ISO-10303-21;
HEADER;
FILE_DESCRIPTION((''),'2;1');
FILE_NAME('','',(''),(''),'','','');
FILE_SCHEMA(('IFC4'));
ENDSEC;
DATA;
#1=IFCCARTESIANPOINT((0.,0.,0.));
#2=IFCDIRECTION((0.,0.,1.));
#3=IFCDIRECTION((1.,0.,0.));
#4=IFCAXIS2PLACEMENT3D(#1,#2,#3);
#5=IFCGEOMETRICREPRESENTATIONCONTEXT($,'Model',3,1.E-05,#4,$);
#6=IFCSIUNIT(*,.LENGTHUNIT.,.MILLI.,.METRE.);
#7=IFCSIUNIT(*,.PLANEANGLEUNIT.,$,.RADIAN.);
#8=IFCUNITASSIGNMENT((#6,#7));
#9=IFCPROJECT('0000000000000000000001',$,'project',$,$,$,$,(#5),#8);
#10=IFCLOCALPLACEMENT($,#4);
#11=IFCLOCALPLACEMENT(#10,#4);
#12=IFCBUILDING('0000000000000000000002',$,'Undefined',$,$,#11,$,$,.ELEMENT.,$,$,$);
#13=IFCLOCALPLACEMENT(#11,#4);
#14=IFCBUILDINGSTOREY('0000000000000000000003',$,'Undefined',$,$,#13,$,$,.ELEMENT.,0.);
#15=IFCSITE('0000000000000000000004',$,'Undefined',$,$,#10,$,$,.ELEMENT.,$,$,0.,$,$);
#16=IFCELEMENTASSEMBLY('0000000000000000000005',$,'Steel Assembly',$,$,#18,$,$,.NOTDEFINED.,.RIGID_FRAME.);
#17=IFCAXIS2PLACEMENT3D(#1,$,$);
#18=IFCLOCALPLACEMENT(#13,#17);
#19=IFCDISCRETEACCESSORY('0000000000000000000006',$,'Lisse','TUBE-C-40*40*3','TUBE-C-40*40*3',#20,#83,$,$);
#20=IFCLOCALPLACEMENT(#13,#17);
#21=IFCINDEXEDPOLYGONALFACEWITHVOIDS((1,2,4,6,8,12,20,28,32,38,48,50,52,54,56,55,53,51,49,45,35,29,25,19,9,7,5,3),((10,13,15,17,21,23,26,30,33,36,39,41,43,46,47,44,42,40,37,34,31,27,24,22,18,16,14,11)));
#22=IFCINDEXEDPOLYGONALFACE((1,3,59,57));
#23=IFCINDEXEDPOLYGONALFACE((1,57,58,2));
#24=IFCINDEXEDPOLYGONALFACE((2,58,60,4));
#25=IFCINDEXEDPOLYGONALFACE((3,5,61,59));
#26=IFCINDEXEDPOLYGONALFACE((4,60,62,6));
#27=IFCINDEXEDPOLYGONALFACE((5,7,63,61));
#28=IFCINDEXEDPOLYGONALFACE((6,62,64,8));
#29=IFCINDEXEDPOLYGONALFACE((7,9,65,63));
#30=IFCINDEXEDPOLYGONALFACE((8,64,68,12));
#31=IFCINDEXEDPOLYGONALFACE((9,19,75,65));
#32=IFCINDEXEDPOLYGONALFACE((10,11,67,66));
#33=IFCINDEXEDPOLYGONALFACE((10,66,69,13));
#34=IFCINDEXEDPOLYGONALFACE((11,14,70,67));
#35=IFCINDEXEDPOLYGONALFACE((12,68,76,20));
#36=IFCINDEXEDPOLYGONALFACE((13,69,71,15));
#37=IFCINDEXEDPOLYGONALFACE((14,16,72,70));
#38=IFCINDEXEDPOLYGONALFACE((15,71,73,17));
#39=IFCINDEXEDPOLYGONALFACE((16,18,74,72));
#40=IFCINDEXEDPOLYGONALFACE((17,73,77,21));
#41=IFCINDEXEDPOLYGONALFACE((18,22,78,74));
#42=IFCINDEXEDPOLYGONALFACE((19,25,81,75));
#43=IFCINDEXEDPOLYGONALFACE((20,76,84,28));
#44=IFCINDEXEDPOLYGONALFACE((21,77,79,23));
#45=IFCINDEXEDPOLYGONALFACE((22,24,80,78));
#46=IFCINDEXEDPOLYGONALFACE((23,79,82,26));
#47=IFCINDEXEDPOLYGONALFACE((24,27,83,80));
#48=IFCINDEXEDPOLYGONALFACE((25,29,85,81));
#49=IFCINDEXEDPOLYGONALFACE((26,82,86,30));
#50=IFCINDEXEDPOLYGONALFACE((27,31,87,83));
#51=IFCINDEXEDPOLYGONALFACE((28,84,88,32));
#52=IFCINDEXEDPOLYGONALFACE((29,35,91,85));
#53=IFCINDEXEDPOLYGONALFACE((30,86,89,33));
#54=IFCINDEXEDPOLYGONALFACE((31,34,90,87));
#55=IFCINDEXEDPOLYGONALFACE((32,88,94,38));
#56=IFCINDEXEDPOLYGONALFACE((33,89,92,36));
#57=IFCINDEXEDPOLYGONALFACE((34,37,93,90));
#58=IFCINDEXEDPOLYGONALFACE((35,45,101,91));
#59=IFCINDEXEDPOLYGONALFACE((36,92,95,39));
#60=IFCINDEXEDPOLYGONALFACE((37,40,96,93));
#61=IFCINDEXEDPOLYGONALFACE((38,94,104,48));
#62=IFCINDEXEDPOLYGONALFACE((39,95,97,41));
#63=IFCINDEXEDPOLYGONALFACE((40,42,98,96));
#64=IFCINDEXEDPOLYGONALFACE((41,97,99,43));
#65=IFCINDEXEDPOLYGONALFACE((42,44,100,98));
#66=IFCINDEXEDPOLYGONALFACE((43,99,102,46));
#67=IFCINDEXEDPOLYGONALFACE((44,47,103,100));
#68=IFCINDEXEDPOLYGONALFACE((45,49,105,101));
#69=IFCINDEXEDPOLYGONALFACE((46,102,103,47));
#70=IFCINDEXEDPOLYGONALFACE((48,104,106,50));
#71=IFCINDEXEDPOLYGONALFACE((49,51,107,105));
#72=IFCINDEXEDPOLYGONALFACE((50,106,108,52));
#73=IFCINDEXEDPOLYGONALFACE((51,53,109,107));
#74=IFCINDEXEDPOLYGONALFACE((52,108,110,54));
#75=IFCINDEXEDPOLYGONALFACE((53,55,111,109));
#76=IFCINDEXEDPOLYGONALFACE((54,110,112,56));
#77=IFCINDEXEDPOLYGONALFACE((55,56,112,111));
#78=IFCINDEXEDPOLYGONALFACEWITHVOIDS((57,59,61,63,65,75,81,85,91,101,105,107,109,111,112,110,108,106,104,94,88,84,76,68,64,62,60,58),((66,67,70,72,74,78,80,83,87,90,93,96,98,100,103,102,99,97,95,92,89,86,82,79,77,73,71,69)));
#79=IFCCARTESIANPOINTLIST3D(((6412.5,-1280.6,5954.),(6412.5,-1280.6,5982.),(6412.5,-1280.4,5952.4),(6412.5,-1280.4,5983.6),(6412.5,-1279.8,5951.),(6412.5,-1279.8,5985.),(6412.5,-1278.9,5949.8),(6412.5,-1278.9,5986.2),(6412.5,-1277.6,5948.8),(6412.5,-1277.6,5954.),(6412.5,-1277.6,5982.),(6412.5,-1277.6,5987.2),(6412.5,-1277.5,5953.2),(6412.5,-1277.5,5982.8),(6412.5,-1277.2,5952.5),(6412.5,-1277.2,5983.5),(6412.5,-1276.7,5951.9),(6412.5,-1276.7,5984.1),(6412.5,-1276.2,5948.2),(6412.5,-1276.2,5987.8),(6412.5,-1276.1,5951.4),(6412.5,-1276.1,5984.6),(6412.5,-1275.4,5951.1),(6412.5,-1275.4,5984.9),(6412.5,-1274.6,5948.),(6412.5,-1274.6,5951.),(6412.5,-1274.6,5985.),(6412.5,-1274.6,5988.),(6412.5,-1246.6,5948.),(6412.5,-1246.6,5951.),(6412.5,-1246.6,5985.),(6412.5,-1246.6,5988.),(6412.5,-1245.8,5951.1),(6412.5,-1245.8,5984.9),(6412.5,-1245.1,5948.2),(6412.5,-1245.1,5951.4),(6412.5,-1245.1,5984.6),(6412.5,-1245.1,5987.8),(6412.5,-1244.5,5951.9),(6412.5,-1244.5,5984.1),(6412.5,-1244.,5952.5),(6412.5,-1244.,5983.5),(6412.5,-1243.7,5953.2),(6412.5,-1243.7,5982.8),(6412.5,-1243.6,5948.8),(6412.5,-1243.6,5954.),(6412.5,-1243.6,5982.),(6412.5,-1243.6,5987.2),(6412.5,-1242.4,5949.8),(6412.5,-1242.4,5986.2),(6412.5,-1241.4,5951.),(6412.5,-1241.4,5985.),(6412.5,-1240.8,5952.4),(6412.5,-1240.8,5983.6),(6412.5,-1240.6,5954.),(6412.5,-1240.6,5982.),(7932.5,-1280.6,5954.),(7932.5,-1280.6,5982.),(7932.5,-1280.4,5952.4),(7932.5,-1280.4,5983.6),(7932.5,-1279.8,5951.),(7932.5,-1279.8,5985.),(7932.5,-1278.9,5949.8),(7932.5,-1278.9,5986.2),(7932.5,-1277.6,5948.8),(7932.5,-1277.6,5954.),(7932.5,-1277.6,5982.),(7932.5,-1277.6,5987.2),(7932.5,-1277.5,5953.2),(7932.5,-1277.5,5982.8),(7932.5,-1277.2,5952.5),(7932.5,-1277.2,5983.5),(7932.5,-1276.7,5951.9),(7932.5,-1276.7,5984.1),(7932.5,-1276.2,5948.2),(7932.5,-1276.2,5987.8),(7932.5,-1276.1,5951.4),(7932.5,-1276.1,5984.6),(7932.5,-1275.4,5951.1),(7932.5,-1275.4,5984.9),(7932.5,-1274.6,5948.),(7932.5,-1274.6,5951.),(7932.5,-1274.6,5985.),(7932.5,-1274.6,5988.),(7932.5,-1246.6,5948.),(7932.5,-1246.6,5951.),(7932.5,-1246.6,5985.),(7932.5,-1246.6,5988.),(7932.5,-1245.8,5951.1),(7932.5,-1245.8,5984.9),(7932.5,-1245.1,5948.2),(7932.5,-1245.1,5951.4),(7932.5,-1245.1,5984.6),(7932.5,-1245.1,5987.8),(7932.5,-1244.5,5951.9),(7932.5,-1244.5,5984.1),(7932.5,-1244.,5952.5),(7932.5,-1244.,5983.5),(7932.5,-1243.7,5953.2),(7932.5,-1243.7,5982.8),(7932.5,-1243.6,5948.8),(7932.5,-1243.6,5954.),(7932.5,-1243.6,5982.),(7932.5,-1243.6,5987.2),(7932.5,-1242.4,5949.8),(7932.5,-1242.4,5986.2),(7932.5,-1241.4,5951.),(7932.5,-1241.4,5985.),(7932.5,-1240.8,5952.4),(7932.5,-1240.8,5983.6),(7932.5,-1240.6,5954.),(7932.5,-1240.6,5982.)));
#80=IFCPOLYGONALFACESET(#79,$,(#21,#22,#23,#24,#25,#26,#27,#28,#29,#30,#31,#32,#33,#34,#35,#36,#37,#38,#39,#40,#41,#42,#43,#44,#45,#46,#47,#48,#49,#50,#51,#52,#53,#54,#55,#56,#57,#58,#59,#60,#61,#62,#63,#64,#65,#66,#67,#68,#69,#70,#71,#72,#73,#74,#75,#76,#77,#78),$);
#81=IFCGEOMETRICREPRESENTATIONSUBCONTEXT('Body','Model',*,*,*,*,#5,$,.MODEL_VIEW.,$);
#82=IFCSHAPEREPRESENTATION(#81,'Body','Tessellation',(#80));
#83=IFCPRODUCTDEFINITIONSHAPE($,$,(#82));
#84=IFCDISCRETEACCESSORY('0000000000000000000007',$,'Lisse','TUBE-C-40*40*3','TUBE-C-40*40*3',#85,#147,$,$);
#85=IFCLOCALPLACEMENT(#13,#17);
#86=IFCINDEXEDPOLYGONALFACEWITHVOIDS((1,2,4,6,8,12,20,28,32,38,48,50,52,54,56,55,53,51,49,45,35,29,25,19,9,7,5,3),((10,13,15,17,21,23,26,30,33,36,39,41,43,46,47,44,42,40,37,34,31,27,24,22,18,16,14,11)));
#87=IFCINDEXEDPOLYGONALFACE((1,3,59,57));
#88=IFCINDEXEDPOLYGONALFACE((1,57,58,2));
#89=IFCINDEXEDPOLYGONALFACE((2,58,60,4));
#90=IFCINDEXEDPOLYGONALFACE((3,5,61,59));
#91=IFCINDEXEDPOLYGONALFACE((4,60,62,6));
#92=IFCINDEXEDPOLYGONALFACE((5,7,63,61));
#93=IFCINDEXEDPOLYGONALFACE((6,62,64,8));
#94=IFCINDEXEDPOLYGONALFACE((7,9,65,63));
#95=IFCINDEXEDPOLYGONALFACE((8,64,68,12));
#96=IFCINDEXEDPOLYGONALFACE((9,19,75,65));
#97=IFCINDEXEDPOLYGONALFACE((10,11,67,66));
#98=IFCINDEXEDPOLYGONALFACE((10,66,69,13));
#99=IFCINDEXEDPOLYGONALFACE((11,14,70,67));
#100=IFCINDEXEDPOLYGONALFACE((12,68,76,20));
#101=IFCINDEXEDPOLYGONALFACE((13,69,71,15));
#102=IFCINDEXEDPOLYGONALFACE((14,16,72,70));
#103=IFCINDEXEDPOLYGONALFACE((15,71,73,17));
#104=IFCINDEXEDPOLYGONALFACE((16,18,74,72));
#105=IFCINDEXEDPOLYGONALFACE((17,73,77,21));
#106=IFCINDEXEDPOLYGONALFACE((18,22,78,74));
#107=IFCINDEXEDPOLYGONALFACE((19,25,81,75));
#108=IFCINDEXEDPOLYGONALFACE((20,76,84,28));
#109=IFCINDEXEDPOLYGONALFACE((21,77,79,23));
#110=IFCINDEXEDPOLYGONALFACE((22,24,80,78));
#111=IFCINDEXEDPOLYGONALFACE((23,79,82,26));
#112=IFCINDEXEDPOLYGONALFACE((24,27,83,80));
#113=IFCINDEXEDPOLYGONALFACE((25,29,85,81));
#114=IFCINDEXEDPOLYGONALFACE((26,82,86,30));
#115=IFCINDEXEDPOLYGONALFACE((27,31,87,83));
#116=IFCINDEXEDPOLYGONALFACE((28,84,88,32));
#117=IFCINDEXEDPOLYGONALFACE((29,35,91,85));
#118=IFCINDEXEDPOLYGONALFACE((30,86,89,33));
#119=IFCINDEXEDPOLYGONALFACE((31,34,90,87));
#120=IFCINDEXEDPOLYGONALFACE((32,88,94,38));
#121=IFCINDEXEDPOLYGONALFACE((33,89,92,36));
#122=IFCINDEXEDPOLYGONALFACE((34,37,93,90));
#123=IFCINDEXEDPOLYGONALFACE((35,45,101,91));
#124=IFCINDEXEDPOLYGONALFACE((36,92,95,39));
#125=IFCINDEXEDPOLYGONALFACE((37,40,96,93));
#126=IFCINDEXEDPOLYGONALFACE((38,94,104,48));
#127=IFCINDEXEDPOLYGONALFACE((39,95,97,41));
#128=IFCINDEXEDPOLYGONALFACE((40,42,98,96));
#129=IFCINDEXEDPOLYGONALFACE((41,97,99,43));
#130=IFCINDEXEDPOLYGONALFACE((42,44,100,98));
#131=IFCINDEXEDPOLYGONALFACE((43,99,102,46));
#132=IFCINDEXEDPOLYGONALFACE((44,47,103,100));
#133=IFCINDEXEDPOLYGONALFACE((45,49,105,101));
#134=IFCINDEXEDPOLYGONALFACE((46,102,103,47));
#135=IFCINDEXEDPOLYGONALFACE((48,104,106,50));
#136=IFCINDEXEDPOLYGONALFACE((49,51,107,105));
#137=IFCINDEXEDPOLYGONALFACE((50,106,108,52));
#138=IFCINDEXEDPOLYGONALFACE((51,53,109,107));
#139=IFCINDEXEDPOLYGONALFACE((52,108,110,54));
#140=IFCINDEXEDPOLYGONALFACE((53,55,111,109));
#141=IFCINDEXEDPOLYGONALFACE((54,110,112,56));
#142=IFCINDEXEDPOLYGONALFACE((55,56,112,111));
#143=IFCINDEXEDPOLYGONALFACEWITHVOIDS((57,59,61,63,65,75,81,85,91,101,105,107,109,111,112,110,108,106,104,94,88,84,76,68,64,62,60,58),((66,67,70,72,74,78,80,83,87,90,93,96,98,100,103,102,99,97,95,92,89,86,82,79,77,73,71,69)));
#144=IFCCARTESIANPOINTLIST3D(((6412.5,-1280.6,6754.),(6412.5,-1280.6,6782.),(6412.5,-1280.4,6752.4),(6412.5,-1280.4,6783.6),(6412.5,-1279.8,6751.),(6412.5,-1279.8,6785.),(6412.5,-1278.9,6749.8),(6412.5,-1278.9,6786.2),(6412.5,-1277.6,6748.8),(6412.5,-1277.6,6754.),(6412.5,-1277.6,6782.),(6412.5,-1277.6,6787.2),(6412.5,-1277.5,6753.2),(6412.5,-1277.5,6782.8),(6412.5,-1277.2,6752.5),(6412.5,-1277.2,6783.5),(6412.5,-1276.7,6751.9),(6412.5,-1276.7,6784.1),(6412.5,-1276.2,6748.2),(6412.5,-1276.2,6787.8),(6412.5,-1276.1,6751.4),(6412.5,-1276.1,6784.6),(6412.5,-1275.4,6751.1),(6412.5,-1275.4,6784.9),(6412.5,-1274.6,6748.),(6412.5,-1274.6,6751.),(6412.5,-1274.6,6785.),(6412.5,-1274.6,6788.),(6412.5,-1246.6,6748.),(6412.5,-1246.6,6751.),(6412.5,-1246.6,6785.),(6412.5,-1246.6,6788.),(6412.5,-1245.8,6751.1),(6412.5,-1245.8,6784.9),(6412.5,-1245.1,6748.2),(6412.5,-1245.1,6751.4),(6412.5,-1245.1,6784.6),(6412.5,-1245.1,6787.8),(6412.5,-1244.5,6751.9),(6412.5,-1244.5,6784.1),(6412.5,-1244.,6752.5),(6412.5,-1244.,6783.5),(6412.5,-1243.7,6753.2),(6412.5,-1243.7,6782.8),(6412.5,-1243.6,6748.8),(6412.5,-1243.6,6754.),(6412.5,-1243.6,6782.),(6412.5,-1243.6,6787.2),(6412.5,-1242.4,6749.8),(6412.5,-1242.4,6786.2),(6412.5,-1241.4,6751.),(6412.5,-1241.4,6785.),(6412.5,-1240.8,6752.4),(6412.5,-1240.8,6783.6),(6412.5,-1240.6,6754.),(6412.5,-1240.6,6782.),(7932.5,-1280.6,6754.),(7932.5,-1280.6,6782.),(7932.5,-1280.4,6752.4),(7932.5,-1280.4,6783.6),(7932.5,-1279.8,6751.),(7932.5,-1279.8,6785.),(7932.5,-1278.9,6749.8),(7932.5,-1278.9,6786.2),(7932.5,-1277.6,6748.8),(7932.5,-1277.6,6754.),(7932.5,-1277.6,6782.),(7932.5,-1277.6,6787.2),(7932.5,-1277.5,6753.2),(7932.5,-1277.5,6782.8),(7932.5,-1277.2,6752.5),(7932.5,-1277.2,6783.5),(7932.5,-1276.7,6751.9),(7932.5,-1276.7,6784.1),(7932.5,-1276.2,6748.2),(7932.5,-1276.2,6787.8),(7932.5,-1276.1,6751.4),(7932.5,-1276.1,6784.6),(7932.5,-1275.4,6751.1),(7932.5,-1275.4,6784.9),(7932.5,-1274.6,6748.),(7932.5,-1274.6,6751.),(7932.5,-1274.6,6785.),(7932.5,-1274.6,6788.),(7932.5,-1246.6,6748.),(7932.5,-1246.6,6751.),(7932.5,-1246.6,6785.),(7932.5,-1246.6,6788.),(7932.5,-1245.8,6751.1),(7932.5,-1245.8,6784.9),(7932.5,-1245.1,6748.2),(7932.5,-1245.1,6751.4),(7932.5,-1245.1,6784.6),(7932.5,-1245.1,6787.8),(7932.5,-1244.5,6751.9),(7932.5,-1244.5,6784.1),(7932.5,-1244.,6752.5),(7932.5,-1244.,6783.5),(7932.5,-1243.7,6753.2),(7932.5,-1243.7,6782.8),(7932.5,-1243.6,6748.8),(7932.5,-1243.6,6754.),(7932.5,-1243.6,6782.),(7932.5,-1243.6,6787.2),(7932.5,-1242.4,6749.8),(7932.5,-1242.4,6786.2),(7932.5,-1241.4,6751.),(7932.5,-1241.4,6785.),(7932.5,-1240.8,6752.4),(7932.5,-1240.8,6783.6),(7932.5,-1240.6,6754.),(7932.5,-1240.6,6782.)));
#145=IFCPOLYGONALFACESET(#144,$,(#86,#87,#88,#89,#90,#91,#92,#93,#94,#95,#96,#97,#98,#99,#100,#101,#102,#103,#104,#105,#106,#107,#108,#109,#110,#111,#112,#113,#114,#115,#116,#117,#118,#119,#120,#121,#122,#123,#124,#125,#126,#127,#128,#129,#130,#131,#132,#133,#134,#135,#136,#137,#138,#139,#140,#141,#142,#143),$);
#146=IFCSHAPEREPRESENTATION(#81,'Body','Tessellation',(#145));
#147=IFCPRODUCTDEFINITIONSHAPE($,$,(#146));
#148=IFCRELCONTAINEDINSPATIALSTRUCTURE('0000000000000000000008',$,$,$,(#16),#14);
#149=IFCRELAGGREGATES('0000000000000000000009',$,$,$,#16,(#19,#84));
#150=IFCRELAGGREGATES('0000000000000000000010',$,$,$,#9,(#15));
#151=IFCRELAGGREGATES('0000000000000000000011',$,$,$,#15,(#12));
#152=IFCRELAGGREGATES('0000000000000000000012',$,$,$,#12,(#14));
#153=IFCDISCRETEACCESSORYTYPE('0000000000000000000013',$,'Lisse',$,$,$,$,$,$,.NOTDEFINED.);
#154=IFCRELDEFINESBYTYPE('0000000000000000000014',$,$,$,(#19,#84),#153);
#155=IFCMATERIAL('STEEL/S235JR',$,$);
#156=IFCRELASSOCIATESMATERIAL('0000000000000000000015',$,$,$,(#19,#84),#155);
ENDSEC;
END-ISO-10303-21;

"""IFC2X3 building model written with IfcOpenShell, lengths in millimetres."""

from ifc_helpers import new_model, si_unit, frame, origin_with_axes, origin_2d_with_axis, place, context, subcontext, project, spatial, hollow_rectangle, extrude, material, type_object, element, aggregate, save


model = new_model("IFC2X3")

# Units and contexts
model_context = context("Model", 3, precision=1e-05, world=origin_with_axes())
body_context = subcontext(model_context, "Body", "Model", "MODEL_VIEW")
ifc_project = project(units=[si_unit("LENGTHUNIT", "METRE", prefix="MILLI"), si_unit("PLANEANGLEUNIT", "RADIAN")], contexts=[model_context])

# Site, building, storey
site_placement = place(None, origin_with_axes())
site = spatial("IfcSite", under=ifc_project, at=site_placement, Name="Undefined", CompositionType="ELEMENT", RefElevation=0.0)
building_placement = place(site_placement, origin_with_axes())
building = spatial("IfcBuilding", under=site, at=building_placement, Name="Undefined", CompositionType="ELEMENT")
storey_placement = place(building_placement, origin_with_axes())
storey = spatial("IfcBuildingStorey", under=building, at=storey_placement, Name="Undefined", CompositionType="ELEMENT", Elevation=0.0)

# Element assembly
assembly_1_placement = place(storey_placement, origin_with_axes())
assembly_1 = element("IfcElementAssembly", 1, at=assembly_1_placement, inside=storey, Name="Steel Assembly", AssemblyPlace="NOTDEFINED", PredefinedType="RIGID_FRAME")
ifc_material_1 = material(Name="STEEL/S235JR")

# Discrete accessories
discrete_accessory_type_1 = type_object("IfcDiscreteAccessoryType", Name="Lisse")
discrete_accessory_1_placement = place(assembly_1_placement, frame((7932.5, -1260.6, 5968.0), z_axis=(0.0, 1.0, 0.0), x_axis=(-1.0, 0.0, 0.0)))
discrete_accessory_1 = element("IfcDiscreteAccessory", 2, at=discrete_accessory_1_placement, type_object=discrete_accessory_type_1, material=ifc_material_1, Name="Lisse", Description="TUBE-C-40*40*3", ObjectType="TUBE-C-40*40*3", context=body_context, shape_type="SweptSolid", body=[
    extrude(hollow_rectangle(XDim=40.0, YDim=40.0, WallThickness=3.0, InnerFilletRadius=3.0, OuterFilletRadius=6.0, at=origin_2d_with_axis()), frame((1520.0, 0.0, 0.0), z_axis=(-1.0, 0.0, 0.0), x_axis=(0.0, -1.0, 0.0)), (0.0, 0.0, 1.0), 1520.0),
])
discrete_accessory_2_placement = place(assembly_1_placement, frame((7932.5, -1260.6, 6768.0), z_axis=(0.0, 1.0, 0.0), x_axis=(-1.0, 0.0, 0.0)))
discrete_accessory_2 = element("IfcDiscreteAccessory", 3, at=discrete_accessory_2_placement, type_object=discrete_accessory_type_1, material=ifc_material_1, Name="Lisse", Description="TUBE-C-40*40*3", ObjectType="TUBE-C-40*40*3", context=body_context, shape_type="SweptSolid", body=[
    extrude(hollow_rectangle(XDim=40.0, YDim=40.0, WallThickness=3.0, InnerFilletRadius=3.0, OuterFilletRadius=6.0, at=origin_2d_with_axis()), frame((1520.0, 0.0, 0.0), z_axis=(-1.0, 0.0, 0.0), x_axis=(0.0, -1.0, 0.0)), (0.0, 0.0, 1.0), 1520.0),
])
aggregate(assembly_1, [discrete_accessory_1, discrete_accessory_2])

save(model, "model.ifc")
